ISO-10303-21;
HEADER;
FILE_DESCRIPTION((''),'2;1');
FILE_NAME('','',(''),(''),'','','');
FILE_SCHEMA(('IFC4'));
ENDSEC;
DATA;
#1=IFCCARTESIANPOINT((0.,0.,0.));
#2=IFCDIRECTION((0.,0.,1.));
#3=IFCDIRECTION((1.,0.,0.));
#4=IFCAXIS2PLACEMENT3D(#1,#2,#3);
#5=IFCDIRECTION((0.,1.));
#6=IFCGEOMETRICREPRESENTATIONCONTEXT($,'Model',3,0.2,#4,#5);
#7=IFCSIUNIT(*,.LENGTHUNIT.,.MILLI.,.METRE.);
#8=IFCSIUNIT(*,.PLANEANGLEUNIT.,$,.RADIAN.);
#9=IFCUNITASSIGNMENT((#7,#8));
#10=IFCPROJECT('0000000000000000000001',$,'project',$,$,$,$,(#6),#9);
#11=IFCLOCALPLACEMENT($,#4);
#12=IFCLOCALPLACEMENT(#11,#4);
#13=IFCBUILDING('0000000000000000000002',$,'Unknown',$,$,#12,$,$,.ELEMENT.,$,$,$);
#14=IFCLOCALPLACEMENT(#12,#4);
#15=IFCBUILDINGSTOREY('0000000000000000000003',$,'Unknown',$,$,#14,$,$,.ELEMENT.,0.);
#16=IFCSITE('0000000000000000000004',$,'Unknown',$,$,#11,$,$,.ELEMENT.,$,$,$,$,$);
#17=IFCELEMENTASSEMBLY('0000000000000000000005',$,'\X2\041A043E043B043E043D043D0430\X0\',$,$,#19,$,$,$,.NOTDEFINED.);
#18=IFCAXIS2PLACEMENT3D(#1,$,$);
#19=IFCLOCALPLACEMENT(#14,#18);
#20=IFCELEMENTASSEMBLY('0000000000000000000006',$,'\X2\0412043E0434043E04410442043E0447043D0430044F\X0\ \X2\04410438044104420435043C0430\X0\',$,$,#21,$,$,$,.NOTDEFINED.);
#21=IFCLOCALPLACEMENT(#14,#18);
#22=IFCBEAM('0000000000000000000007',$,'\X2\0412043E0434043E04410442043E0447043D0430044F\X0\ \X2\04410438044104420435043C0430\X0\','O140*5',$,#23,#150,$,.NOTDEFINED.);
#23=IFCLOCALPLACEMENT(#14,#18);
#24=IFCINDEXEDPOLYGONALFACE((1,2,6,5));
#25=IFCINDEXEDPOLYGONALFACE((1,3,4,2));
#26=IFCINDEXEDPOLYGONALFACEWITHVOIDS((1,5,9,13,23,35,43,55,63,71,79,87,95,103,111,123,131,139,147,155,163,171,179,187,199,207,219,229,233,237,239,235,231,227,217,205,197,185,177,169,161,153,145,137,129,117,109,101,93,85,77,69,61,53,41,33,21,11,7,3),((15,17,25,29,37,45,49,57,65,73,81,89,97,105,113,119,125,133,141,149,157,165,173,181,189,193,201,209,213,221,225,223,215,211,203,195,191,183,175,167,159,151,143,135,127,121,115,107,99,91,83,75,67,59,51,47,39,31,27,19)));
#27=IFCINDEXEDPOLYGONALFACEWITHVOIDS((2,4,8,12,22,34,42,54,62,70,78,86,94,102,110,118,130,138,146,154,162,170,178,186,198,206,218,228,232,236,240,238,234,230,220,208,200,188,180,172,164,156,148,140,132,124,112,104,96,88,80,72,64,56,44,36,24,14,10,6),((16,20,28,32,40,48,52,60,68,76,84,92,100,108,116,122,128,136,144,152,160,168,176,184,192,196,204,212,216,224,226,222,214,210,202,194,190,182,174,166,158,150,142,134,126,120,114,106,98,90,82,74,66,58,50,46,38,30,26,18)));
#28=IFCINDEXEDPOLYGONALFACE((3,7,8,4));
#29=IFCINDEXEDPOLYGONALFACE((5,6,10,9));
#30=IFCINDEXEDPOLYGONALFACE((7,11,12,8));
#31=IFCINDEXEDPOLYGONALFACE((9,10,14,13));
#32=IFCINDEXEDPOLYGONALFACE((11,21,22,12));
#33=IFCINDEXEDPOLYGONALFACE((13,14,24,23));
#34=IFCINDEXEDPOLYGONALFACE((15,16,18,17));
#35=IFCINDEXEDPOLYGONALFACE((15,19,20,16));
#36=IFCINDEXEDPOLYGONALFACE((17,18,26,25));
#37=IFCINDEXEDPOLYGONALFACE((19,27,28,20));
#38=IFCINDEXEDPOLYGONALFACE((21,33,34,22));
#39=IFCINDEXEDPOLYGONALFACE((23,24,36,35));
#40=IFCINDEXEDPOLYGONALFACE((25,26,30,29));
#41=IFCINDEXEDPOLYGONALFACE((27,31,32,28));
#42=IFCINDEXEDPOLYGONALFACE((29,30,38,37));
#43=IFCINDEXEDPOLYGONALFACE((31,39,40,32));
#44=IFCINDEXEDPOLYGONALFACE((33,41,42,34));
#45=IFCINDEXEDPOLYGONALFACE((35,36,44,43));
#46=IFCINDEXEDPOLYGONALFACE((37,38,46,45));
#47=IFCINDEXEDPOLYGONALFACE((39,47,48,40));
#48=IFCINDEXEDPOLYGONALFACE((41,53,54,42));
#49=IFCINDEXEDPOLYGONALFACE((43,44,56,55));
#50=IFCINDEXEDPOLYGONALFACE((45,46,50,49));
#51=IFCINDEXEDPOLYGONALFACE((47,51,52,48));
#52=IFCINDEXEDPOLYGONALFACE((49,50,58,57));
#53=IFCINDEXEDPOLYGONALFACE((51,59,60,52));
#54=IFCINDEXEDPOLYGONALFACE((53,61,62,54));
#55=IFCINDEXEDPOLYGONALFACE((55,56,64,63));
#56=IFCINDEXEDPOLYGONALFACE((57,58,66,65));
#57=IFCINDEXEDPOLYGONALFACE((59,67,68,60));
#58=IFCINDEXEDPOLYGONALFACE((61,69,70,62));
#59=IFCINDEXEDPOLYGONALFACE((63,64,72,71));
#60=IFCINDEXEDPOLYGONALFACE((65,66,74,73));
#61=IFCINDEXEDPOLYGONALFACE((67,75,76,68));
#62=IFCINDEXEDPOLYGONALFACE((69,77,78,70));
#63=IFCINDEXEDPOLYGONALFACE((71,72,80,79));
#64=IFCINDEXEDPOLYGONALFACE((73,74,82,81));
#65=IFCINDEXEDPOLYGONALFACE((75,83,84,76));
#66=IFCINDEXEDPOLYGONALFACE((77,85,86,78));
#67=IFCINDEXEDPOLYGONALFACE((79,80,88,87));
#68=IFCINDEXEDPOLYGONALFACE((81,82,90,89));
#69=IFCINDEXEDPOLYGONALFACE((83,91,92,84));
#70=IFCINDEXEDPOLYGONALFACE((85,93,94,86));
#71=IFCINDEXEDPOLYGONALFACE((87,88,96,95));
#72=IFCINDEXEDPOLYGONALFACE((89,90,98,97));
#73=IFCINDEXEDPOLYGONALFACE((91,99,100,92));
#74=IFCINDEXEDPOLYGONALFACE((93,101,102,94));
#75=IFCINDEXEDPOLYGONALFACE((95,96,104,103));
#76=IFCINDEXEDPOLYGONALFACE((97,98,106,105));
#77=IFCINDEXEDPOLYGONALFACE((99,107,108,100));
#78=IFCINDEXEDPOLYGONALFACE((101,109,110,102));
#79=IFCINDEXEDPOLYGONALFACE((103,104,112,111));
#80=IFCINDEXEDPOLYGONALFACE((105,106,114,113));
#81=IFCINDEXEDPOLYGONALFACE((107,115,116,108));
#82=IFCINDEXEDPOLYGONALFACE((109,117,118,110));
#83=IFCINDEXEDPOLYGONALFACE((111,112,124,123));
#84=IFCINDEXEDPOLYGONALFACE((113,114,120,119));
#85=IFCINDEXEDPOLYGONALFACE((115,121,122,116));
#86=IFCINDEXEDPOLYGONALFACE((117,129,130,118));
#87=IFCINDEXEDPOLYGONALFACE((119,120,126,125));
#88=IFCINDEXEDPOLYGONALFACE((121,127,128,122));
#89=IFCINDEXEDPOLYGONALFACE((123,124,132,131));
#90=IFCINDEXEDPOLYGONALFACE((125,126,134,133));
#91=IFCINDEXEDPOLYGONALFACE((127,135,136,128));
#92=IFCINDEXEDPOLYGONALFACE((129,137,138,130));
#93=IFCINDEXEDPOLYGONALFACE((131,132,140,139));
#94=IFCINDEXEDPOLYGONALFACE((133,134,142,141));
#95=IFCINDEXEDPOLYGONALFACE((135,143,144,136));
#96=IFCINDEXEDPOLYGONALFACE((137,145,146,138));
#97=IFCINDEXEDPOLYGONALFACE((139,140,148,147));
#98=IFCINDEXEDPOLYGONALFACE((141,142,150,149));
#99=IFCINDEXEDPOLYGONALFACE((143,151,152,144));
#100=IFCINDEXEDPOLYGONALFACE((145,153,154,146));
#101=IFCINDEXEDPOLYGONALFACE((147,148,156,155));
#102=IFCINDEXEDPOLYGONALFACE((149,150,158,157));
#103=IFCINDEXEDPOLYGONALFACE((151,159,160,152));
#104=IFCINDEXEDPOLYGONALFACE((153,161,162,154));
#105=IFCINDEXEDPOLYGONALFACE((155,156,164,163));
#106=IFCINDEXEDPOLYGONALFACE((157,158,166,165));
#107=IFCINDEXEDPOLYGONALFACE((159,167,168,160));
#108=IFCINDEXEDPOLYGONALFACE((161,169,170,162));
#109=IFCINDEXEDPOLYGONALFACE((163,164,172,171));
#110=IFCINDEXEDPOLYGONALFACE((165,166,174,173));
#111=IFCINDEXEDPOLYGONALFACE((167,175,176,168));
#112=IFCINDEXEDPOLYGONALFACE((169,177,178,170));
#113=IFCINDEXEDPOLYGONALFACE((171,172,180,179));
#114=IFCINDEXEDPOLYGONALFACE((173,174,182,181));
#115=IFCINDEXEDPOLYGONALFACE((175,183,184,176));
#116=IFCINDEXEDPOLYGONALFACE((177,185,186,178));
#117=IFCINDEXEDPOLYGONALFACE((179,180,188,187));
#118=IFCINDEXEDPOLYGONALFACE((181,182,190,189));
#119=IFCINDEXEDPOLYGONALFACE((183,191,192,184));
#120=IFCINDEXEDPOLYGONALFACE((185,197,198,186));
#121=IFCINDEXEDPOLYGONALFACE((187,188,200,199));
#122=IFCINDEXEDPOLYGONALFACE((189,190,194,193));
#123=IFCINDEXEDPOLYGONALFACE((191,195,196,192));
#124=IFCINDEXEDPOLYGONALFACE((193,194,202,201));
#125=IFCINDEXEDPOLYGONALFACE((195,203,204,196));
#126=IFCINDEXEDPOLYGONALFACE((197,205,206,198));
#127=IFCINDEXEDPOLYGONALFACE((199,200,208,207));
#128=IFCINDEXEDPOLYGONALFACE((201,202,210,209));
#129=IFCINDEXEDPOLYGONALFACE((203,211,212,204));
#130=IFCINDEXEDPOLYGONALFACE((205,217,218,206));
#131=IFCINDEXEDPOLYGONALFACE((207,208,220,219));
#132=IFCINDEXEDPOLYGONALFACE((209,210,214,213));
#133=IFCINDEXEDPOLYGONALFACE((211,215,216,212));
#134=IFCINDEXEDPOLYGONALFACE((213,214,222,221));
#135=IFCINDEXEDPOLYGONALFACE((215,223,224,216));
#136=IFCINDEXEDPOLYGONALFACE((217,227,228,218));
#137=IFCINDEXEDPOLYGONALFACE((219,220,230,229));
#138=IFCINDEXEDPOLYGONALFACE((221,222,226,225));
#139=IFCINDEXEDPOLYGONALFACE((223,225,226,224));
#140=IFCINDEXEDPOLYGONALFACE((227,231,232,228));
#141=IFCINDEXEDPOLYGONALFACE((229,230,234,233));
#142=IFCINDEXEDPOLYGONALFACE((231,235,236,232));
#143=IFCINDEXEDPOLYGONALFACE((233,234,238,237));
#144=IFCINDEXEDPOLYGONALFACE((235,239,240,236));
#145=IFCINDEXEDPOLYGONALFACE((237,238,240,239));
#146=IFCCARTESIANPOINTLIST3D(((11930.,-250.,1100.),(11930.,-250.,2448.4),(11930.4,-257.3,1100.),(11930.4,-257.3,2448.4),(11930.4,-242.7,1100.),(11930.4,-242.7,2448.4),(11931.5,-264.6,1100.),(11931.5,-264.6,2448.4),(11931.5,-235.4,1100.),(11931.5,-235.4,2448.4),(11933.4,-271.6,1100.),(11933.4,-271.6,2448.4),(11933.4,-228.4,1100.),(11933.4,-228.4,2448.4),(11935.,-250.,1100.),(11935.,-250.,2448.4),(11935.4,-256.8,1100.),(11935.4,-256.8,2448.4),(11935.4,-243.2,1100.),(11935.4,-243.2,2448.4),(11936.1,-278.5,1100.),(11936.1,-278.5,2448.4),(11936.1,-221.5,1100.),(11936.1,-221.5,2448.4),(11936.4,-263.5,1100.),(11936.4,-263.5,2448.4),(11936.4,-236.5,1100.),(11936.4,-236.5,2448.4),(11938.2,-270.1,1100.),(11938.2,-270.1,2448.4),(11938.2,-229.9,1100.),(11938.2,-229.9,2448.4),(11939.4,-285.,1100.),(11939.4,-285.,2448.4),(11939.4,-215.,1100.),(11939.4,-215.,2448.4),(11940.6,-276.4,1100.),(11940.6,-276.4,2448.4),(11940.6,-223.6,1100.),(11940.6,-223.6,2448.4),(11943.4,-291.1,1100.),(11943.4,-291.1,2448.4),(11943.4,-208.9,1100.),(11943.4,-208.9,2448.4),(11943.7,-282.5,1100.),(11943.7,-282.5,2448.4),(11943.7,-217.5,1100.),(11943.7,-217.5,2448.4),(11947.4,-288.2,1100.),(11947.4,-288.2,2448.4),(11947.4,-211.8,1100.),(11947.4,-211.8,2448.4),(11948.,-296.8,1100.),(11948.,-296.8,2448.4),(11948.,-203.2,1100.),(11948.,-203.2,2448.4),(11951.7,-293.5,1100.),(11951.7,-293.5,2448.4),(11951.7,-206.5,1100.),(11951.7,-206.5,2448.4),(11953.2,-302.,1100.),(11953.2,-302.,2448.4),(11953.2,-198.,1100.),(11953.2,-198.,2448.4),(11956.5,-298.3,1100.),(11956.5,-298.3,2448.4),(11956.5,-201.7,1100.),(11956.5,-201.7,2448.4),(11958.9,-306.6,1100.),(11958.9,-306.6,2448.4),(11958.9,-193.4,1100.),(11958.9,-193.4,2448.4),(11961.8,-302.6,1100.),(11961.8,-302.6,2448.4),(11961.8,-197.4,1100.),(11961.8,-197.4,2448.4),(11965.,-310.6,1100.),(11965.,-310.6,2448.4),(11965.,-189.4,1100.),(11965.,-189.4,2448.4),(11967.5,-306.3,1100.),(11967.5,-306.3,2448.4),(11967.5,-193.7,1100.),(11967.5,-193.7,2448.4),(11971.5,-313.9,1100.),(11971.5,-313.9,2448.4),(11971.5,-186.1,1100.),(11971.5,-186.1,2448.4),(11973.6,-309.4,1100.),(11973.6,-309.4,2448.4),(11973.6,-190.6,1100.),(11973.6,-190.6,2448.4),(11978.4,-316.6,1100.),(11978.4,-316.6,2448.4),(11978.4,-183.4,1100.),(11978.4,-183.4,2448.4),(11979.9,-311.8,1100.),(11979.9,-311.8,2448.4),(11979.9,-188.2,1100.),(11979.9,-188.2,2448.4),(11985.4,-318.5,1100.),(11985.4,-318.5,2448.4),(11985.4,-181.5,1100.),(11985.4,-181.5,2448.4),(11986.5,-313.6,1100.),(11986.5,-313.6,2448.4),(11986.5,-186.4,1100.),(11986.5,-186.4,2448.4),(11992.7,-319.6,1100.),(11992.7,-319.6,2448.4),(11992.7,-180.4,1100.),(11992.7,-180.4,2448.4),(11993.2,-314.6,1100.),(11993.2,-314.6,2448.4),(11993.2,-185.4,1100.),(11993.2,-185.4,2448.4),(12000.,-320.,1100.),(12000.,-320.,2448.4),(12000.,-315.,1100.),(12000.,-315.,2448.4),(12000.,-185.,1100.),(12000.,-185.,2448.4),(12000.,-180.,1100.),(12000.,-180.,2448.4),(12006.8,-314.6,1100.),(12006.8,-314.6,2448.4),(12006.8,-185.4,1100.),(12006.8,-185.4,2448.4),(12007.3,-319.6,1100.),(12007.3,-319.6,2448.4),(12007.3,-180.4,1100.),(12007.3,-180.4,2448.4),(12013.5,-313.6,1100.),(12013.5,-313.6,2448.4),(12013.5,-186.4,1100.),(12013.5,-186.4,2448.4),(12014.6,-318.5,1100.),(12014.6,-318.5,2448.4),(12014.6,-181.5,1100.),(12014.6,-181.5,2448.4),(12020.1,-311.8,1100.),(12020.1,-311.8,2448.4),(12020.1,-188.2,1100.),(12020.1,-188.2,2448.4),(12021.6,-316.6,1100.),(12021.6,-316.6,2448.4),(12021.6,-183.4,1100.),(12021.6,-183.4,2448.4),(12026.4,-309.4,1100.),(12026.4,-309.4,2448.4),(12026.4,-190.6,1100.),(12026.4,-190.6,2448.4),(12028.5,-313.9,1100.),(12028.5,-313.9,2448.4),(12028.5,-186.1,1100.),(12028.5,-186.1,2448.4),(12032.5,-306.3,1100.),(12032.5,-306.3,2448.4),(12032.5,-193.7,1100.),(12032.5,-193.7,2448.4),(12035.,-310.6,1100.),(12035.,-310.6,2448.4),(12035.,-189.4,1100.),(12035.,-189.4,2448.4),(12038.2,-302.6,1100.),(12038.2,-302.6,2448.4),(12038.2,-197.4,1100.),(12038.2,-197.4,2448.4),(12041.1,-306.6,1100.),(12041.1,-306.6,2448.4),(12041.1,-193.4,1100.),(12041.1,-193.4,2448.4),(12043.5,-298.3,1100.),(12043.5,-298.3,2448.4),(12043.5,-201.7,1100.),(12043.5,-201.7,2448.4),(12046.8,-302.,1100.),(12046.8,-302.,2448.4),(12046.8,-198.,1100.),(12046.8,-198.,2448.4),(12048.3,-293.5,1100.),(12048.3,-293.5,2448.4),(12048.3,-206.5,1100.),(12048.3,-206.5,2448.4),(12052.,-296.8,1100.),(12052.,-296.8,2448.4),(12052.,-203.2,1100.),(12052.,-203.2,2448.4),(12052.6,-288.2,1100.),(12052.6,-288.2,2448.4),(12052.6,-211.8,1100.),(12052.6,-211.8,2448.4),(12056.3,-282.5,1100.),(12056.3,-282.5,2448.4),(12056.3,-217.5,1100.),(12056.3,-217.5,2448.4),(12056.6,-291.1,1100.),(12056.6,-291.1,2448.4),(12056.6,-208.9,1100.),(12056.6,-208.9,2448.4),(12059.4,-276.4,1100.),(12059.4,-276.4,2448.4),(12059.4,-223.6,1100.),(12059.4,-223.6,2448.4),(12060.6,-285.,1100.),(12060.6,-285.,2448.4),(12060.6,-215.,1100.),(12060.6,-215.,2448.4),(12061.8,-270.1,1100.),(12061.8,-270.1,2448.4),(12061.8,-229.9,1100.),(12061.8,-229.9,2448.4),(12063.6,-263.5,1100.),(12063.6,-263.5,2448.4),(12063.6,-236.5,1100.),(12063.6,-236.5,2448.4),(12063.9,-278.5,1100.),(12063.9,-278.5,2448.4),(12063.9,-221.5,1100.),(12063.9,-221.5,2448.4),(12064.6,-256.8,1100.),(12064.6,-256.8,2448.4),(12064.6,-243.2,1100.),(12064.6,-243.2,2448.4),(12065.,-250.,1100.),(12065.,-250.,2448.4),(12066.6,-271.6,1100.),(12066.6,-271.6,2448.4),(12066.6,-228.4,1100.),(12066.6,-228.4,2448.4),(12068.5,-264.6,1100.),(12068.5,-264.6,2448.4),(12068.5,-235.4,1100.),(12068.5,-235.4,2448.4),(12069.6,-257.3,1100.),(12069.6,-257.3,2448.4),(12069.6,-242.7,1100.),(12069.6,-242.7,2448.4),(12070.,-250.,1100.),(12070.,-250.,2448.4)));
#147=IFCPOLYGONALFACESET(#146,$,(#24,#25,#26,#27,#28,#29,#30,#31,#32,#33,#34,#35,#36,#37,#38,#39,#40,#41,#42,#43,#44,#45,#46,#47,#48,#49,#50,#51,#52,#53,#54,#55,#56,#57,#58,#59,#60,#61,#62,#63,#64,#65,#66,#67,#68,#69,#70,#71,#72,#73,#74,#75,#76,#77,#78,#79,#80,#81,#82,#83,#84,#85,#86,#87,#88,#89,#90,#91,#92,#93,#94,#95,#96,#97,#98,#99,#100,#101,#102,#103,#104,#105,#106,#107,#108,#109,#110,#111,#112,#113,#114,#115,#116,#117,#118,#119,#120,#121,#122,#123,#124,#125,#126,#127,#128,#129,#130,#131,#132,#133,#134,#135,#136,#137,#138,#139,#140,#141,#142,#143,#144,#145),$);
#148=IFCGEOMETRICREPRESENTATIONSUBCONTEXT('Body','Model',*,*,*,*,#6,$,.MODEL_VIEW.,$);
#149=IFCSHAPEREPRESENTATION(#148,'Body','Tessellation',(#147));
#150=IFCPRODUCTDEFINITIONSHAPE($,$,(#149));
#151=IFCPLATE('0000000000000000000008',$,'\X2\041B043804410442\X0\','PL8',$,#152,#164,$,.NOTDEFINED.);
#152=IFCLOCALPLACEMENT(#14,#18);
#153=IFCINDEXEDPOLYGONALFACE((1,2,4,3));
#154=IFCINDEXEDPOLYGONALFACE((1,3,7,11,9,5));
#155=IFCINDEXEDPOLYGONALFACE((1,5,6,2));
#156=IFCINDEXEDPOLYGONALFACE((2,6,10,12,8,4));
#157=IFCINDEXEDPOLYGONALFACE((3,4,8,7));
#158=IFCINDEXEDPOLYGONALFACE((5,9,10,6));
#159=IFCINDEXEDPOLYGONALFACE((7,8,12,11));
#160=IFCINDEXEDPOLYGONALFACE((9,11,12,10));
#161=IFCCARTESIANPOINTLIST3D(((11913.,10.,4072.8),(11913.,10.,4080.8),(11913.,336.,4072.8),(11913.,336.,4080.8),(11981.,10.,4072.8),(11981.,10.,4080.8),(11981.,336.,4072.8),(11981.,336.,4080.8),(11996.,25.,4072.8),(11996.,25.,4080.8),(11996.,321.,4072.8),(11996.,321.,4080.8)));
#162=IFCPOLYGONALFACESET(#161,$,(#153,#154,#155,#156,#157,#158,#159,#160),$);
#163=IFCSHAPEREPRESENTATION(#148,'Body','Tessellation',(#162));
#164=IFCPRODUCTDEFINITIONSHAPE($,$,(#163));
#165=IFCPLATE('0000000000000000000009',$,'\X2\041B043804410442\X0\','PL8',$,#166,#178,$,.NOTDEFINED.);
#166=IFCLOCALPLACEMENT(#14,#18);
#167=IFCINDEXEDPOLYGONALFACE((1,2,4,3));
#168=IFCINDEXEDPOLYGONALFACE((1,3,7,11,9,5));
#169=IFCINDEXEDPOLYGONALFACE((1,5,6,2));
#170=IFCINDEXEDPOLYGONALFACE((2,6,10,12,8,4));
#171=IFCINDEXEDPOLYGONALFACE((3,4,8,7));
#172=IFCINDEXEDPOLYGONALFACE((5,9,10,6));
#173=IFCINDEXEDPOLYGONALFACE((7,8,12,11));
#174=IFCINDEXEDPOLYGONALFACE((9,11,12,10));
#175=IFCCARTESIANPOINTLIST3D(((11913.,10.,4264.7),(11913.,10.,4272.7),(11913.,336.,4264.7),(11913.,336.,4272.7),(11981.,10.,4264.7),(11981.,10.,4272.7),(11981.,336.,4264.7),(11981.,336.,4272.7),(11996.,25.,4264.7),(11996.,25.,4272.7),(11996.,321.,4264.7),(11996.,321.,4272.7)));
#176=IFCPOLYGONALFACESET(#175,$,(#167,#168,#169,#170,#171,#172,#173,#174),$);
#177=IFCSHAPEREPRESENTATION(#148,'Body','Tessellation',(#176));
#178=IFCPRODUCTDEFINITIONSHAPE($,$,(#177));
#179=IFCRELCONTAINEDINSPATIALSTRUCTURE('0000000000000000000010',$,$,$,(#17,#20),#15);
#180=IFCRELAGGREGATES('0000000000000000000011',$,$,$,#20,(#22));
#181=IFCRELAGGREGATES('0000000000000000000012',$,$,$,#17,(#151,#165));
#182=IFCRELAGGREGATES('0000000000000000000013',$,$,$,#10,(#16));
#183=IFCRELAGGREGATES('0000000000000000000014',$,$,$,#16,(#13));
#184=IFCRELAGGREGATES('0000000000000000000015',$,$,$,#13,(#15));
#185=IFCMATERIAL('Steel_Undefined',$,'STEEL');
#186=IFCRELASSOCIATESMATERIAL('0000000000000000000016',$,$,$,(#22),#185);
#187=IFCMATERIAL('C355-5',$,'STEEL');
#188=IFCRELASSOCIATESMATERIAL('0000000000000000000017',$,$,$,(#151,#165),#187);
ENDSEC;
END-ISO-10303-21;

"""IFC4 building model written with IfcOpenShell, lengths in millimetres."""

from ifc_helpers import new_model, si_unit, direction, frame, origin_with_axes, place, context, subcontext, project, spatial, line, indexed_curve, outline, extrude, material, element, aggregate, save


model = new_model("IFC4")

# Units and contexts
model_context = context("Model", 3, precision=0.2, world=origin_with_axes(), true_north=direction((0.0, 1.0)))
body_context = subcontext(model_context, "Body", "Model", "MODEL_VIEW")
ifc_project = project(units=[si_unit("LENGTHUNIT", "METRE", prefix="MILLI"), si_unit("PLANEANGLEUNIT", "RADIAN")], contexts=[model_context])

# Site, building, storey
site_placement = place(None, origin_with_axes())
site = spatial("IfcSite", under=ifc_project, at=site_placement, Name="Unknown", CompositionType="ELEMENT")
building_placement = place(site_placement, origin_with_axes())
building = spatial("IfcBuilding", under=site, at=building_placement, Name="Unknown", CompositionType="ELEMENT")
storey_placement = place(building_placement, origin_with_axes())
storey = spatial("IfcBuildingStorey", under=building, at=storey_placement, Name="Unknown", CompositionType="ELEMENT", Elevation=0.0)

# Element assembly
assembly_1_placement = place(storey_placement, frame((12000.0, 173.0, -200.0), z_axis=(-1.0, 0.0, 0.0), x_axis=(0.0, 0.0, 1.0)))
assembly_1 = element("IfcElementAssembly", 1, at=assembly_1_placement, inside=storey, Name="Колонна", PredefinedType="NOTDEFINED")
ifc_material_1 = material(Name="C355-5", Category="STEEL")

# Element assembly, beam
ifc_material_2 = material(Name="Steel_Undefined", Category="STEEL")
assembly_2_placement = place(storey_placement, frame((12000.0, -250.0, 2448.4), z_axis=(0.0, 1.0, 0.0), x_axis=(0.0, 0.0, -1.0)))
assembly_2 = element("IfcElementAssembly", 2, at=assembly_2_placement, inside=storey, Name="Водосточная система", PredefinedType="NOTDEFINED")
beam_1_placement = place(assembly_2_placement, origin_with_axes())
beam_1 = element("IfcBeam", 3, at=beam_1_placement, material=ifc_material_2, Name="Водосточная система", Description="O140*5", PredefinedType="NOTDEFINED", context=body_context, shape_type="SolidModel", body=[
    extrude(outline(indexed_curve([(70.0, 0.0), (69.6, 7.3), (68.5, 14.6), (66.6, 21.6), (63.9, 28.5), (60.6, 35.0), (56.6, 41.1), (52.0, 46.8), (46.8, 52.0), (41.1, 56.6), (35.0, 60.6), (28.5, 63.9), (21.6, 66.6), (14.6, 68.5), (7.3, 69.6), (0.0, 70.0), (-7.3, 69.6), (-14.6, 68.5), (-21.6, 66.6), (-28.5, 63.9), (-35.0, 60.6), (-41.1, 56.6), (-46.8, 52.0), (-52.0, 46.8), (-56.6, 41.1), (-60.6, 35.0), (-63.9, 28.5), (-66.6, 21.6), (-68.5, 14.6), (-69.6, 7.3), (-70.0, 0.0), (-69.6, -7.3), (-68.5, -14.6), (-66.6, -21.6), (-63.9, -28.5), (-60.6, -35.0), (-56.6, -41.1), (-52.0, -46.8), (-46.8, -52.0), (-41.1, -56.6), (-35.0, -60.6), (-28.5, -63.9), (-21.6, -66.6), (-14.6, -68.5), (-7.3, -69.6), (0.0, -70.0), (7.3, -69.6), (14.6, -68.5), (21.6, -66.6), (28.5, -63.9), (35.0, -60.6), (41.1, -56.6), (46.8, -52.0), (52.0, -46.8), (56.6, -41.1), (60.6, -35.0), (63.9, -28.5), (66.6, -21.6), (68.5, -14.6), (69.6, -7.3)], segments=[line(1, 2, 3, 4, 5, 6, 7, 8, 9, 10, 11, 12, 13, 14, 15, 16, 17, 18, 19, 20, 21, 22, 23, 24, 25, 26, 27, 28, 29, 30, 31, 32, 33, 34, 35, 36, 37, 38, 39, 40, 41, 42, 43, 44, 45, 46, 47, 48, 49, 50, 51, 52, 53, 54, 55, 56, 57, 58, 59, 60, 1)]), holes=[indexed_curve([(65.0, 0.0), (64.6, -6.8), (63.6, -13.5), (61.8, -20.1), (59.4, -26.4), (56.3, -32.5), (52.6, -38.2), (48.3, -43.5), (43.5, -48.3), (38.2, -52.6), (32.5, -56.3), (26.4, -59.4), (20.1, -61.8), (13.5, -63.6), (6.8, -64.6), (0.0, -65.0), (-6.8, -64.6), (-13.5, -63.6), (-20.1, -61.8), (-26.4, -59.4), (-32.5, -56.3), (-38.2, -52.6), (-43.5, -48.3), (-48.3, -43.5), (-52.6, -38.2), (-56.3, -32.5), (-59.4, -26.4), (-61.8, -20.1), (-63.6, -13.5), (-64.6, -6.8), (-65.0, 0.0), (-64.6, 6.8), (-63.6, 13.5), (-61.8, 20.1), (-59.4, 26.4), (-56.3, 32.5), (-52.6, 38.2), (-48.3, 43.5), (-43.5, 48.3), (-38.2, 52.6), (-32.5, 56.3), (-26.4, 59.4), (-20.1, 61.8), (-13.5, 63.6), (-6.8, 64.6), (0.0, 65.0), (6.8, 64.6), (13.5, 63.6), (20.1, 61.8), (26.4, 59.4), (32.5, 56.3), (38.2, 52.6), (43.5, 48.3), (48.3, 43.5), (52.6, 38.2), (56.3, 32.5), (59.4, 26.4), (61.8, 20.1), (63.6, 13.5), (64.6, 6.8)], segments=[line(1, 2, 3, 4, 5, 6, 7, 8, 9, 10, 11, 12, 13, 14, 15, 16, 17, 18, 19, 20, 21, 22, 23, 24, 25, 26, 27, 28, 29, 30, 31, 32, 33, 34, 35, 36, 37, 38, 39, 40, 41, 42, 43, 44, 45, 46, 47, 48, 49, 50, 51, 52, 53, 54, 55, 56, 57, 58, 59, 60, 1)])]), frame((0.0, 0.0, 0.0), z_axis=(-1.0, 0.0, 0.0), x_axis=(0.0, 0.0, 1.0)), (0.0, 0.0, -1.0), 1348.4),
])
aggregate(assembly_2, [beam_1])

# Plates
plate_1_placement = place(assembly_1_placement, frame((4276.8, 163.0, 87.0), z_axis=(-1.0, 0.0, 0.0), x_axis=(0.0, 0.0, -1.0)))
plate_1 = element("IfcPlate", 4, at=plate_1_placement, material=ifc_material_1, Name="Лист", Description="PL8", PredefinedType="NOTDEFINED", context=body_context, shape_type="SolidModel", body=[
    extrude(outline(indexed_curve([(0.0, 0.0), (68.0, 0.0), (83.0, 15.0), (83.0, 311.0), (68.0, 326.0), (0.0, 326.0)], segments=[line(1, 2, 3, 4, 5, 6, 1)])), frame((0.0, 0.0, 4.0), z_axis=(0.0, 0.0, 1.0), x_axis=(1.0, 0.0, 0.0)), (0.0, 0.0, -1.0), 8.0),
])
plate_2_placement = place(assembly_1_placement, frame((4468.7, 163.0, 87.0), z_axis=(-1.0, 0.0, 0.0), x_axis=(0.0, 0.0, -1.0)))
plate_2 = element("IfcPlate", 5, at=plate_2_placement, material=ifc_material_1, Name="Лист", Description="PL8", PredefinedType="NOTDEFINED", context=body_context, shape_type="SolidModel", body=[
    extrude(outline(indexed_curve([(0.0, 0.0), (68.0, 0.0), (83.0, 15.0), (83.0, 311.0), (68.0, 326.0), (0.0, 326.0)], segments=[line(1, 2, 3, 4, 5, 6, 1)])), frame((0.0, 0.0, 4.0), z_axis=(0.0, 0.0, 1.0), x_axis=(1.0, 0.0, 0.0)), (0.0, 0.0, -1.0), 8.0),
])
aggregate(assembly_1, [plate_1, plate_2])

save(model, "model.ifc")
